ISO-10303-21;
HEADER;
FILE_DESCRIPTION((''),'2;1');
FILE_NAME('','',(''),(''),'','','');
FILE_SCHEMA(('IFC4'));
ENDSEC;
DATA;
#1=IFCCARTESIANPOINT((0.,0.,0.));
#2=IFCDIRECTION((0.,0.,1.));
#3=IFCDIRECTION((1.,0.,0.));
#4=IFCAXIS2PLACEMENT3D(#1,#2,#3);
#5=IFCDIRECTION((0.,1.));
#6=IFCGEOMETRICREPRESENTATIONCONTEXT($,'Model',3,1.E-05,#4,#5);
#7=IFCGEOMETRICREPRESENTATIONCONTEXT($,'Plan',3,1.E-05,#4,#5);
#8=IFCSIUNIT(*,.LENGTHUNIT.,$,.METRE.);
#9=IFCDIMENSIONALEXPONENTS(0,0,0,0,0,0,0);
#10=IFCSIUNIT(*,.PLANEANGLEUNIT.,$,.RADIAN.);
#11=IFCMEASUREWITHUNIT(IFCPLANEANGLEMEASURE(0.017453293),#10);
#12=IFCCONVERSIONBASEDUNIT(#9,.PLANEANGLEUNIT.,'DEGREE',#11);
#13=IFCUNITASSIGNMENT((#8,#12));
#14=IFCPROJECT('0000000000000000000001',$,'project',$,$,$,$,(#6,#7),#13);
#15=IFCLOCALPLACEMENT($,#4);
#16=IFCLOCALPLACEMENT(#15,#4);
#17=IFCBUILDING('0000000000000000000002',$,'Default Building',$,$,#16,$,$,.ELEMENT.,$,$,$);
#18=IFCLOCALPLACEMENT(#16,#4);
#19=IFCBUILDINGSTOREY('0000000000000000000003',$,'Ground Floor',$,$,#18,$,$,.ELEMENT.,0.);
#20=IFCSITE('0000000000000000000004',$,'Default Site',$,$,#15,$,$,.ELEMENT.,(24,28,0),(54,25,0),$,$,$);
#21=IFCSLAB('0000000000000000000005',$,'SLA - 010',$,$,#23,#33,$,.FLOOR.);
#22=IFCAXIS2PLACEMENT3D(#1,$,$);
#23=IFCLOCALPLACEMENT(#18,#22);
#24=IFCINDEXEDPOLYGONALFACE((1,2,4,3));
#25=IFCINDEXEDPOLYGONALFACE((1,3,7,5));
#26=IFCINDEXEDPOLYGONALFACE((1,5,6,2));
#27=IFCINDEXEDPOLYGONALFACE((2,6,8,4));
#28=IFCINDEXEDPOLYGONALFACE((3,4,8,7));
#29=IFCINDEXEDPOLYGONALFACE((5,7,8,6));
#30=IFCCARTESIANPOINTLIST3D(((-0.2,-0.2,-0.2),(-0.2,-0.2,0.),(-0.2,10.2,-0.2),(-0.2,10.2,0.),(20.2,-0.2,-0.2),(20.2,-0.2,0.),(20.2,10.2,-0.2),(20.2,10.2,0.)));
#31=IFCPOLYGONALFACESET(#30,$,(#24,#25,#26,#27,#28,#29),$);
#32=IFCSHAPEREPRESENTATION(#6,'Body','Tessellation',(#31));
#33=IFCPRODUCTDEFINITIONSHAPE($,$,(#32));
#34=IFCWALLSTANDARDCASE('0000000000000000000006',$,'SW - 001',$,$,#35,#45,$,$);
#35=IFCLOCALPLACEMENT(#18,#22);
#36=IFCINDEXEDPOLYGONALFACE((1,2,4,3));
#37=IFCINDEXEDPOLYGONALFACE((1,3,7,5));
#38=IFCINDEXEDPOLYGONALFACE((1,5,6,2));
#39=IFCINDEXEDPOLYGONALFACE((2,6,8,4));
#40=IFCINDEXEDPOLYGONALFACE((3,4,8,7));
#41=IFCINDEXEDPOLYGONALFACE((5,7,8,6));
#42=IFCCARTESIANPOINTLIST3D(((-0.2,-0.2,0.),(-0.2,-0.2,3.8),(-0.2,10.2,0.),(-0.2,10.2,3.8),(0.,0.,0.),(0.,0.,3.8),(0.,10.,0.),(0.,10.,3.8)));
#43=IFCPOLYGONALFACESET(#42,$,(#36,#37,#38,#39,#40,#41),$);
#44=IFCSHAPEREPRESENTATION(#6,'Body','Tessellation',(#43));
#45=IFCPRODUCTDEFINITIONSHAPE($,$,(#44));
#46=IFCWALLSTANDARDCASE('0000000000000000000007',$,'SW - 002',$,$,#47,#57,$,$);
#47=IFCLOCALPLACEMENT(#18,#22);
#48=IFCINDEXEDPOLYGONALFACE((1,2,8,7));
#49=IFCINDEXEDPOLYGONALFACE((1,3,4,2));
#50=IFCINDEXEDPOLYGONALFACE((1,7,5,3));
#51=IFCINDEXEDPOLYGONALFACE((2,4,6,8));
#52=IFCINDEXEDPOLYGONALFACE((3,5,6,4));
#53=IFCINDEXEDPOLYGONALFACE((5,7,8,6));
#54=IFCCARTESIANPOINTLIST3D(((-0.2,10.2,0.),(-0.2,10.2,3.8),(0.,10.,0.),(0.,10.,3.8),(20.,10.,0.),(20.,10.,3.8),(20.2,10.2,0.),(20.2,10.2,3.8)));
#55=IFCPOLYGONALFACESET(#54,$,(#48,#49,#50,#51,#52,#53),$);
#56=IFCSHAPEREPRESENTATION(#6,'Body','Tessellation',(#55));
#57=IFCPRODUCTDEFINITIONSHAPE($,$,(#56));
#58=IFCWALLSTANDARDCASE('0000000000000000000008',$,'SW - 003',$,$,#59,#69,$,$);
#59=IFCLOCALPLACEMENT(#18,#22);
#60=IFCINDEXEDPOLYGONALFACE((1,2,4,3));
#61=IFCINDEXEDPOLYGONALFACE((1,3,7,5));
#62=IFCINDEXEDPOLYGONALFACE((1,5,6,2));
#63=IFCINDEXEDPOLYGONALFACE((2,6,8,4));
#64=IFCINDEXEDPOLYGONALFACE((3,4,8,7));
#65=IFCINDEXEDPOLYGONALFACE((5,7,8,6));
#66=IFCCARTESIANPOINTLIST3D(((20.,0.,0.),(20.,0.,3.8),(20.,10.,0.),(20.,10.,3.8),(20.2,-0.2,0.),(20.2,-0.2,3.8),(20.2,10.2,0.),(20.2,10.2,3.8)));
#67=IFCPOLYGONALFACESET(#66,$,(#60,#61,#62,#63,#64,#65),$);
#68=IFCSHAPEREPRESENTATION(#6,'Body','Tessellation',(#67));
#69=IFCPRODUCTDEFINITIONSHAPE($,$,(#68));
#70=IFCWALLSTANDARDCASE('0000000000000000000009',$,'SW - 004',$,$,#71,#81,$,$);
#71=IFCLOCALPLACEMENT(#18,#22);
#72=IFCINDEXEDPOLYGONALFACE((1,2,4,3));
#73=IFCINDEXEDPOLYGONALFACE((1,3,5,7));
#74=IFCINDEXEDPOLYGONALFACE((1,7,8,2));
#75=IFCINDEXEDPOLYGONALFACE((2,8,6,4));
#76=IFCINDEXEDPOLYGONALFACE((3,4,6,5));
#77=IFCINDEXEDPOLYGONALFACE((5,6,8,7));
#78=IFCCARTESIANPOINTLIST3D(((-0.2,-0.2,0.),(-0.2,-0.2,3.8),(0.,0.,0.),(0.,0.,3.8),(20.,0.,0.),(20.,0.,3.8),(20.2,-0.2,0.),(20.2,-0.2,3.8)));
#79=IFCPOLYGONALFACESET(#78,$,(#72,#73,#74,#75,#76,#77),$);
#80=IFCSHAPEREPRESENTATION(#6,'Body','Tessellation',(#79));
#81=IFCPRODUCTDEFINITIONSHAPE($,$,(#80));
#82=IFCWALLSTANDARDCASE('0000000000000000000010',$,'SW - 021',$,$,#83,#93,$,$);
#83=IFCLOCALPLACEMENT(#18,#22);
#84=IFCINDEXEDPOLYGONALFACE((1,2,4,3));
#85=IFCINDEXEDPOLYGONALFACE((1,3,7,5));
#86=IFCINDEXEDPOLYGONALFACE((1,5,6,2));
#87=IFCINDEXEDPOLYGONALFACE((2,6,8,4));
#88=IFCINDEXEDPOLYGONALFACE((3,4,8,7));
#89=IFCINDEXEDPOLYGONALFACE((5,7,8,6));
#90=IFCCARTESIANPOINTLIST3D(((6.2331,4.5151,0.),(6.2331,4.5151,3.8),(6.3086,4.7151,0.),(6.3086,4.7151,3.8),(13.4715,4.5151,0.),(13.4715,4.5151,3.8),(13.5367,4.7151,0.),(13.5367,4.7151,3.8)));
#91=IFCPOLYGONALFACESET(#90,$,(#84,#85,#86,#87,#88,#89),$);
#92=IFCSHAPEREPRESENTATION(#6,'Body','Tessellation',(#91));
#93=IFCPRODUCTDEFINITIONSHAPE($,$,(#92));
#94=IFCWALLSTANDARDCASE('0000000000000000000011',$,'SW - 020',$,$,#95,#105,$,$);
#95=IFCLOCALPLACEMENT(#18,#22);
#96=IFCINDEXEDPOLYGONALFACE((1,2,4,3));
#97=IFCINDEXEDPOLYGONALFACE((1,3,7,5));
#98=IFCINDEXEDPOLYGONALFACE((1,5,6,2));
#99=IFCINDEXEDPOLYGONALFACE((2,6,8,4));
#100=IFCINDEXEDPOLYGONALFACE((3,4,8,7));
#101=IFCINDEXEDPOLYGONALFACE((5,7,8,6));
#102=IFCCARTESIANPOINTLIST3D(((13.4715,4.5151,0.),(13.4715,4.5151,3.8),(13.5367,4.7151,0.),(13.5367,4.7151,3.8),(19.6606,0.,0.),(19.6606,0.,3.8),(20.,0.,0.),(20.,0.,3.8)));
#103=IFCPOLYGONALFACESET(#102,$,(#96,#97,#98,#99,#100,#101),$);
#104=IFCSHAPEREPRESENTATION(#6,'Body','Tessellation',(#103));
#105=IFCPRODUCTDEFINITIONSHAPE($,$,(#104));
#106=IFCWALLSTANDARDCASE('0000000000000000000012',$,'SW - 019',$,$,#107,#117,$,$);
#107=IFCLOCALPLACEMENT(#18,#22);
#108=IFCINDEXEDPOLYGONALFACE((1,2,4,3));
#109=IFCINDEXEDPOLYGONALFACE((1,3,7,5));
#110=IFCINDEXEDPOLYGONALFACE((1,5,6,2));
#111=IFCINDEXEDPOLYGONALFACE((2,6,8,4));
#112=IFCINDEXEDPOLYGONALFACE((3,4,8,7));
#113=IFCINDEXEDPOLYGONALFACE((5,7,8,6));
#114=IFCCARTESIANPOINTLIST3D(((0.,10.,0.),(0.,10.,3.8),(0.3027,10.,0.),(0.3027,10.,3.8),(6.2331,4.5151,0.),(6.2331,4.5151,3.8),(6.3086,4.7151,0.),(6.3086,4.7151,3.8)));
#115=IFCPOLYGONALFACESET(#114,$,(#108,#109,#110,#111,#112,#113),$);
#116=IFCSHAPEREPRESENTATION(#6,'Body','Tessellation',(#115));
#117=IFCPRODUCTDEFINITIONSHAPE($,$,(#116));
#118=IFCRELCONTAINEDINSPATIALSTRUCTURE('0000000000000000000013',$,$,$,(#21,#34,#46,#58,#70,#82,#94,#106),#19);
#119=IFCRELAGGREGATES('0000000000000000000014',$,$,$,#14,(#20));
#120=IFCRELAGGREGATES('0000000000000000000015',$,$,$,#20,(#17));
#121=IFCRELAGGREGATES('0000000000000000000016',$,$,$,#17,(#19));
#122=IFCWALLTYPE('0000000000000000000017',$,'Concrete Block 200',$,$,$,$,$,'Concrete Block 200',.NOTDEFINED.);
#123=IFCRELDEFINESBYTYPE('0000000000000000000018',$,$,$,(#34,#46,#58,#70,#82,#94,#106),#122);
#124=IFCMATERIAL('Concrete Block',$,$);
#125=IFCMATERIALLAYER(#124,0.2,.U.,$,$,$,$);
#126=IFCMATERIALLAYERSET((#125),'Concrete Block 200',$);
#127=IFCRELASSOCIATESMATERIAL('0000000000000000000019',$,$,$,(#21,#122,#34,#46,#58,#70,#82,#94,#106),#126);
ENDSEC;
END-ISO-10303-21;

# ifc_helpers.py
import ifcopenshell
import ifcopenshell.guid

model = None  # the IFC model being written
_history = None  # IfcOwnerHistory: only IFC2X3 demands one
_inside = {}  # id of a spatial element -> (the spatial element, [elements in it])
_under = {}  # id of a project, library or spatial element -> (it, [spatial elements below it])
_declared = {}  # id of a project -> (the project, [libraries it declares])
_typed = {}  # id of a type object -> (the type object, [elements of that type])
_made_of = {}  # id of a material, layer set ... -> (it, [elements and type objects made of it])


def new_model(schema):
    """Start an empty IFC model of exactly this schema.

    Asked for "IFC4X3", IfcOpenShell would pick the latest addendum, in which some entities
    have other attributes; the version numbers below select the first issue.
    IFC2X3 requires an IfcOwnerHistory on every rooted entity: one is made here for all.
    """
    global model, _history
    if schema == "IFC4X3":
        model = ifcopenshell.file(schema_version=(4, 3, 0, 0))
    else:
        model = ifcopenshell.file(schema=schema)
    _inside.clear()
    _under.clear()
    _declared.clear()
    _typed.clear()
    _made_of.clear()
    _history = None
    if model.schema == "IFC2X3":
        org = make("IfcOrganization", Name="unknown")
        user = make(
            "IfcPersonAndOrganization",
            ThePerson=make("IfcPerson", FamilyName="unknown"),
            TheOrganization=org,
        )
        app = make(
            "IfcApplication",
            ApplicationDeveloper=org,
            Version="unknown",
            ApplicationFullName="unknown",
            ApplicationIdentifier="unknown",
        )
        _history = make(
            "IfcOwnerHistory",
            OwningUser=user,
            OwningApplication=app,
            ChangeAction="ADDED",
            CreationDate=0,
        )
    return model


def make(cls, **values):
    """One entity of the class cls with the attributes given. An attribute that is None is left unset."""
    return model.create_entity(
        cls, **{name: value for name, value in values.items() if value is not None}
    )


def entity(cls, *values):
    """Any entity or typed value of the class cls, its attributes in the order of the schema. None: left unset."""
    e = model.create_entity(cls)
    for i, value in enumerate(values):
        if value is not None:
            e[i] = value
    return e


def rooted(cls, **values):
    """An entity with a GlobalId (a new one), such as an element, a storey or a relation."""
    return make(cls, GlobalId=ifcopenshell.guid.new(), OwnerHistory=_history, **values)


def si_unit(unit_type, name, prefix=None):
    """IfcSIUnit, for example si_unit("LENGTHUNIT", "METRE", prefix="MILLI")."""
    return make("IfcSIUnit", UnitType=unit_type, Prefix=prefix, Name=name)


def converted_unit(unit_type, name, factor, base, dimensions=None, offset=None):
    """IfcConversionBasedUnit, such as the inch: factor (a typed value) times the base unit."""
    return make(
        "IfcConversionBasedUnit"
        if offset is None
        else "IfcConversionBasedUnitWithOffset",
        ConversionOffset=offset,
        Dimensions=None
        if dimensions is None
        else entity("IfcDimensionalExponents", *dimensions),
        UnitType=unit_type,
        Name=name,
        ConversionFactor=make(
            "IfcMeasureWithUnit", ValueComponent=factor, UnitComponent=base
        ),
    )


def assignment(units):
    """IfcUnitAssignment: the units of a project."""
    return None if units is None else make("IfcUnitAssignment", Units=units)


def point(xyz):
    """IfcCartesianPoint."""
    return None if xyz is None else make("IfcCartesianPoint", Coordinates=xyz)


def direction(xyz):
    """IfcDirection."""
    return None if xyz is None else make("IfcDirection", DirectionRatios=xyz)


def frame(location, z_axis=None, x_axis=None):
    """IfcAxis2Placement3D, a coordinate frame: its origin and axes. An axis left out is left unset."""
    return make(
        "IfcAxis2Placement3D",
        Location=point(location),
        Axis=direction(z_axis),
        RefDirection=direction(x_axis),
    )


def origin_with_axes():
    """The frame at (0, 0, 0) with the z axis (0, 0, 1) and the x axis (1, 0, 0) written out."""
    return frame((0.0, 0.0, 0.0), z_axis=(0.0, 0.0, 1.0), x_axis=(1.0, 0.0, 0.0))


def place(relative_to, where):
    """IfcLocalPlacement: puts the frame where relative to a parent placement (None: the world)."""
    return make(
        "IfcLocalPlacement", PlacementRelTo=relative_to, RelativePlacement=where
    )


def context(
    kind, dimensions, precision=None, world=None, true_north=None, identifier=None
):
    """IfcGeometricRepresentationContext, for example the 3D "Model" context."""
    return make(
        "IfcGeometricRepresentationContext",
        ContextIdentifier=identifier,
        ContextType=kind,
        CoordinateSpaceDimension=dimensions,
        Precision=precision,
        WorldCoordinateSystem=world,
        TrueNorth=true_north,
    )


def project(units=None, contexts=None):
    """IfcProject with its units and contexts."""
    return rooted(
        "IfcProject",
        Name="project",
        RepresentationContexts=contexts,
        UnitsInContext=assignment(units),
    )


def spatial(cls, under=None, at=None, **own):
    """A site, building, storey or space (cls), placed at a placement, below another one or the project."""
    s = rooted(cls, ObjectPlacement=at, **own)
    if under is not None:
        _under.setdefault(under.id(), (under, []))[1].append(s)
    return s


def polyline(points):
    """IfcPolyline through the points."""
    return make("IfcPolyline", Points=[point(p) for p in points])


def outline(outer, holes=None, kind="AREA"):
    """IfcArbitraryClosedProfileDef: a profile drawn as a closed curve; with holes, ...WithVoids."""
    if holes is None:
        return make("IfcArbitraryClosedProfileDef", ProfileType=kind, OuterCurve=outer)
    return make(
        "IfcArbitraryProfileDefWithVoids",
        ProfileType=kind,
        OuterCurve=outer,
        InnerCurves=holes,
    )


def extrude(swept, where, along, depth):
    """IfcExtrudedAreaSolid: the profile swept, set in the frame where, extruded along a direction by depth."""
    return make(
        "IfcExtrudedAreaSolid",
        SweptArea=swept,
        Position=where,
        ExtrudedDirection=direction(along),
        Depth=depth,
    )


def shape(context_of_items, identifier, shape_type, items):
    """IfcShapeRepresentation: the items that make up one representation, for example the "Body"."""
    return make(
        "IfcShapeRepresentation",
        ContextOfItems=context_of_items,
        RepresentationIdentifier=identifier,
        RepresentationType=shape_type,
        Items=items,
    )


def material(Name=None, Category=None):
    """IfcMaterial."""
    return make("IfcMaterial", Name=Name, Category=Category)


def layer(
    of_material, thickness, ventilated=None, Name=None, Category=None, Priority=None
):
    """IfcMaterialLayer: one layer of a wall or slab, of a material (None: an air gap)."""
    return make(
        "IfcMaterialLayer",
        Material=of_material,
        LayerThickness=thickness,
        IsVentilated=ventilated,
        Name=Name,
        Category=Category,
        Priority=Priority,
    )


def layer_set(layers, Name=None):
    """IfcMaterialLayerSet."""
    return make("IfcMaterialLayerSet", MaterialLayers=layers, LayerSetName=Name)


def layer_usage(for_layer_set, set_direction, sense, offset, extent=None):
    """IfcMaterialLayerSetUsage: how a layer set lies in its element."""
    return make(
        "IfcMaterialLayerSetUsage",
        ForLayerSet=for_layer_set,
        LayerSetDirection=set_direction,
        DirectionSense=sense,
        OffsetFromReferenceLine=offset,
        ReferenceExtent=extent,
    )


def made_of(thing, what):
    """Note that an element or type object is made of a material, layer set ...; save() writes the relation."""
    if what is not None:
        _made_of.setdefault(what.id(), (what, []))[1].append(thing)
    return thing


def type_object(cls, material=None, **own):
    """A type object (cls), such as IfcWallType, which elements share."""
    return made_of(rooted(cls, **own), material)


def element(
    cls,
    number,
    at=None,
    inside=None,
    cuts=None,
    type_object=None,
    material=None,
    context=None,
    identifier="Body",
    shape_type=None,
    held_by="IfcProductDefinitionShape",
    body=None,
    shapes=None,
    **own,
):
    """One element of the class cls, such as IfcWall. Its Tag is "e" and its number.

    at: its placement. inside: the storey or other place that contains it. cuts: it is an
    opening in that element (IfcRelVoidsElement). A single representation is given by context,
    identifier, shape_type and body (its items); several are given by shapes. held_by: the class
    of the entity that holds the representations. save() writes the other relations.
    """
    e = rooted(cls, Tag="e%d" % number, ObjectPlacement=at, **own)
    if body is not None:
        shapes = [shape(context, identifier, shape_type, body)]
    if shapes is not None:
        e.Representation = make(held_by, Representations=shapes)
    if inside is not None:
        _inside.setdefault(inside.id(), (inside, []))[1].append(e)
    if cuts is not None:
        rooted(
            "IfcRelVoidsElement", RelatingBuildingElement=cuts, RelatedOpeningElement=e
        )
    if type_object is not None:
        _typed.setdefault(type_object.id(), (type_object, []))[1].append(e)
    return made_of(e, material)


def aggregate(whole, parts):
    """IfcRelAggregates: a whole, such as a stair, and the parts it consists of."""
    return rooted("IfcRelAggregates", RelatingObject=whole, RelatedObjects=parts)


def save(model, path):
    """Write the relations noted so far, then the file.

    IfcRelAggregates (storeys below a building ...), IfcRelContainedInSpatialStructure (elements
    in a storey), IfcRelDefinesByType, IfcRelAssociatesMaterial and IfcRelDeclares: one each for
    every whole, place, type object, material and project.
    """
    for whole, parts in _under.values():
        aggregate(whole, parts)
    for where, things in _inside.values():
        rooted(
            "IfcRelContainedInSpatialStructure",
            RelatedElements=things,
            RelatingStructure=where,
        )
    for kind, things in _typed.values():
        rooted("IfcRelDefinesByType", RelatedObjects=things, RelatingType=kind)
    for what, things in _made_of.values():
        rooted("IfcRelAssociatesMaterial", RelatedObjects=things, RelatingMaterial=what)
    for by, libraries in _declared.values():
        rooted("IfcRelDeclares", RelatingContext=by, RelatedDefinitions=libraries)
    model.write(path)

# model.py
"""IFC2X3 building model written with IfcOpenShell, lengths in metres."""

from ifc_helpers import new_model, entity, si_unit, converted_unit, direction, frame, origin_with_axes, place, context, project, spatial, polyline, outline, extrude, material, layer, layer_set, layer_usage, type_object, element, save


model = new_model("IFC2X3")

# Units and contexts
model_context = context("Model", 3, precision=1e-05, world=origin_with_axes(), true_north=direction((0.0, 1.0)))
plan_context = context("Plan", 3, precision=1e-05, world=origin_with_axes(), true_north=direction((0.0, 1.0)))
ifc_project = project(units=[si_unit("LENGTHUNIT", "METRE"), converted_unit("PLANEANGLEUNIT", "DEGREE", entity("IfcPlaneAngleMeasure", 0.017453293), si_unit("PLANEANGLEUNIT", "RADIAN"), dimensions=[0, 0, 0, 0, 0, 0, 0])], contexts=[model_context, plan_context])

# Site, building, storey
site_placement = place(None, origin_with_axes())
site = spatial("IfcSite", under=ifc_project, at=site_placement, Name="Default Site", CompositionType="ELEMENT", RefLatitude=(24, 28, 0), RefLongitude=(54, 25, 0))
building_placement = place(site_placement, origin_with_axes())
building = spatial("IfcBuilding", under=site, at=building_placement, Name="Default Building", CompositionType="ELEMENT")
storey_placement = place(building_placement, origin_with_axes())
storey = spatial("IfcBuildingStorey", under=building, at=storey_placement, Name="Ground Floor", CompositionType="ELEMENT", Elevation=0.0)

# Slab
ifc_material = material(Name="Concrete Block")
ifc_layer = layer(ifc_material, 0.2, ventilated="UNKNOWN")
ifc_layer_set = layer_set([ifc_layer], Name="Concrete Block 200")
ifc_layer_usage_1 = layer_usage(ifc_layer_set, "AXIS3", "NEGATIVE", 0.2)
slab_placement = place(storey_placement, frame((-0.2, 10.2, -0.2), z_axis=(0.0, 0.0, 1.0), x_axis=(1.0, 0.0, 0.0)))
element("IfcSlab", 1, at=slab_placement, inside=storey, material=ifc_layer_usage_1, Name="SLA - 010", PredefinedType="FLOOR", context=model_context, shape_type="SweptSolid", body=[
    extrude(outline(polyline([(0.0, 0.0), (20.4, 0.0), (20.4, -10.4), (0.0, -10.4), (0.0, 0.0)])), origin_with_axes(), (0.0, 0.0, 1.0), 0.2),
])

# Walls
ifc_layer_usage_2 = layer_usage(ifc_layer_set, "AXIS2", "POSITIVE", 0.0)
wall_type = type_object("IfcWallType", Name="Concrete Block 200", ElementType="Concrete Block 200", PredefinedType="NOTDEFINED", material=ifc_layer_set)
wall_1_placement = place(storey_placement, frame((0.0, 0.0, 0.0), z_axis=(0.0, 0.0, 1.0), x_axis=(0.0, 1.0, 0.0)))
element("IfcWallStandardCase", 2, at=wall_1_placement, inside=storey, type_object=wall_type, material=ifc_layer_usage_2, Name="SW - 001", context=model_context, shape_type="SweptSolid", body=[
    extrude(outline(polyline([(0.0, 0.0), (10.0, 0.0), (10.2, 0.2), (-0.2, 0.2), (0.0, 0.0)])), origin_with_axes(), (0.0, 0.0, 1.0), 3.8),
])
ifc_layer_usage_3 = layer_usage(ifc_layer_set, "AXIS2", "POSITIVE", 0.0)
wall_2_placement = place(storey_placement, frame((0.0, 10.0, 0.0), z_axis=(0.0, 0.0, 1.0), x_axis=(1.0, 0.0, 0.0)))
element("IfcWallStandardCase", 3, at=wall_2_placement, inside=storey, type_object=wall_type, material=ifc_layer_usage_3, Name="SW - 002", context=model_context, shape_type="SweptSolid", body=[
    extrude(outline(polyline([(0.0, 0.0), (20.0, 0.0), (20.2, 0.2), (-0.2, 0.2), (0.0, 0.0)])), origin_with_axes(), (0.0, 0.0, 1.0), 3.8),
])
ifc_layer_usage_4 = layer_usage(ifc_layer_set, "AXIS2", "POSITIVE", 0.0)
wall_3_placement = place(storey_placement, frame((20.0, 10.0, 0.0), z_axis=(0.0, 0.0, 1.0), x_axis=(0.0, -1.0, 0.0)))
element("IfcWallStandardCase", 4, at=wall_3_placement, inside=storey, type_object=wall_type, material=ifc_layer_usage_4, Name="SW - 003", context=model_context, shape_type="SweptSolid", body=[
    extrude(outline(polyline([(0.0, 0.0), (10.0, 0.0), (10.2, 0.2), (-0.2, 0.2), (0.0, 0.0)])), origin_with_axes(), (0.0, 0.0, 1.0), 3.8),
])
ifc_layer_usage_5 = layer_usage(ifc_layer_set, "AXIS2", "POSITIVE", 0.0)
wall_4_placement = place(storey_placement, frame((20.0, 0.0, 0.0), z_axis=(0.0, 0.0, 1.0), x_axis=(-1.0, 0.0, 0.0)))
element("IfcWallStandardCase", 5, at=wall_4_placement, inside=storey, type_object=wall_type, material=ifc_layer_usage_5, Name="SW - 004", context=model_context, shape_type="SweptSolid", body=[
    extrude(outline(polyline([(0.0, 0.0), (20.0, 0.0), (20.2, 0.2), (-0.2, 0.2), (0.0, 0.0)])), origin_with_axes(), (0.0, 0.0, 1.0), 3.8),
])
ifc_layer_usage_6 = layer_usage(ifc_layer_set, "AXIS2", "NEGATIVE", 0.0)
wall_5_placement = place(storey_placement, frame((13.4715, 4.5151, 0.0), z_axis=(0.0, 0.0, 1.0), x_axis=(-1.0, 0.0, 0.0)))
element("IfcWallStandardCase", 6, at=wall_5_placement, inside=storey, type_object=wall_type, material=ifc_layer_usage_6, Name="SW - 021", context=model_context, shape_type="SweptSolid", body=[
    extrude(outline(polyline([(-0.0652, -0.2), (7.1629, -0.2), (7.2384, 0.0), (0.0, 0.0), (-0.0652, -0.2)])), origin_with_axes(), (0.0, 0.0, 1.0), 3.8),
])
ifc_layer_usage_7 = layer_usage(ifc_layer_set, "AXIS2", "NEGATIVE", 0.0)
wall_6_placement = place(storey_placement, frame((19.6606, 0.0, 0.0), z_axis=(0.0, 0.0, 1.0), x_axis=(-0.807873, 0.589356, 0.0)))
element("IfcWallStandardCase", 7, at=wall_6_placement, inside=storey, type_object=wall_type, material=ifc_layer_usage_7, Name="SW - 020", context=model_context, shape_type="SweptSolid", body=[
    extrude(outline(polyline([(-0.2742, -0.2), (7.7262, -0.2), (7.661, 0.0), (0.0, 0.0), (-0.2742, -0.2)])), origin_with_axes(), (0.0, 0.0, 1.0), 3.8),
])
ifc_layer_usage_8 = layer_usage(ifc_layer_set, "AXIS2", "NEGATIVE", 0.0)
wall_7_placement = place(storey_placement, frame((0.3027, 10.0, 0.0), z_axis=(0.0, 0.0, 1.0), x_axis=(0.750727, -0.660613, 0.0)))
element("IfcWallStandardCase", 8, at=wall_7_placement, inside=storey, type_object=wall_type, material=ifc_layer_usage_8, Name="SW - 019", context=model_context, shape_type="SweptSolid", body=[
    extrude(outline(polyline([(-0.2273, -0.2), (8.0755, -0.2), (8.0001, 0.0), (0.0, 0.0), (-0.2273, -0.2)])), origin_with_axes(), (0.0, 0.0, 1.0), 3.8),
])

save(model, "model.ifc")
